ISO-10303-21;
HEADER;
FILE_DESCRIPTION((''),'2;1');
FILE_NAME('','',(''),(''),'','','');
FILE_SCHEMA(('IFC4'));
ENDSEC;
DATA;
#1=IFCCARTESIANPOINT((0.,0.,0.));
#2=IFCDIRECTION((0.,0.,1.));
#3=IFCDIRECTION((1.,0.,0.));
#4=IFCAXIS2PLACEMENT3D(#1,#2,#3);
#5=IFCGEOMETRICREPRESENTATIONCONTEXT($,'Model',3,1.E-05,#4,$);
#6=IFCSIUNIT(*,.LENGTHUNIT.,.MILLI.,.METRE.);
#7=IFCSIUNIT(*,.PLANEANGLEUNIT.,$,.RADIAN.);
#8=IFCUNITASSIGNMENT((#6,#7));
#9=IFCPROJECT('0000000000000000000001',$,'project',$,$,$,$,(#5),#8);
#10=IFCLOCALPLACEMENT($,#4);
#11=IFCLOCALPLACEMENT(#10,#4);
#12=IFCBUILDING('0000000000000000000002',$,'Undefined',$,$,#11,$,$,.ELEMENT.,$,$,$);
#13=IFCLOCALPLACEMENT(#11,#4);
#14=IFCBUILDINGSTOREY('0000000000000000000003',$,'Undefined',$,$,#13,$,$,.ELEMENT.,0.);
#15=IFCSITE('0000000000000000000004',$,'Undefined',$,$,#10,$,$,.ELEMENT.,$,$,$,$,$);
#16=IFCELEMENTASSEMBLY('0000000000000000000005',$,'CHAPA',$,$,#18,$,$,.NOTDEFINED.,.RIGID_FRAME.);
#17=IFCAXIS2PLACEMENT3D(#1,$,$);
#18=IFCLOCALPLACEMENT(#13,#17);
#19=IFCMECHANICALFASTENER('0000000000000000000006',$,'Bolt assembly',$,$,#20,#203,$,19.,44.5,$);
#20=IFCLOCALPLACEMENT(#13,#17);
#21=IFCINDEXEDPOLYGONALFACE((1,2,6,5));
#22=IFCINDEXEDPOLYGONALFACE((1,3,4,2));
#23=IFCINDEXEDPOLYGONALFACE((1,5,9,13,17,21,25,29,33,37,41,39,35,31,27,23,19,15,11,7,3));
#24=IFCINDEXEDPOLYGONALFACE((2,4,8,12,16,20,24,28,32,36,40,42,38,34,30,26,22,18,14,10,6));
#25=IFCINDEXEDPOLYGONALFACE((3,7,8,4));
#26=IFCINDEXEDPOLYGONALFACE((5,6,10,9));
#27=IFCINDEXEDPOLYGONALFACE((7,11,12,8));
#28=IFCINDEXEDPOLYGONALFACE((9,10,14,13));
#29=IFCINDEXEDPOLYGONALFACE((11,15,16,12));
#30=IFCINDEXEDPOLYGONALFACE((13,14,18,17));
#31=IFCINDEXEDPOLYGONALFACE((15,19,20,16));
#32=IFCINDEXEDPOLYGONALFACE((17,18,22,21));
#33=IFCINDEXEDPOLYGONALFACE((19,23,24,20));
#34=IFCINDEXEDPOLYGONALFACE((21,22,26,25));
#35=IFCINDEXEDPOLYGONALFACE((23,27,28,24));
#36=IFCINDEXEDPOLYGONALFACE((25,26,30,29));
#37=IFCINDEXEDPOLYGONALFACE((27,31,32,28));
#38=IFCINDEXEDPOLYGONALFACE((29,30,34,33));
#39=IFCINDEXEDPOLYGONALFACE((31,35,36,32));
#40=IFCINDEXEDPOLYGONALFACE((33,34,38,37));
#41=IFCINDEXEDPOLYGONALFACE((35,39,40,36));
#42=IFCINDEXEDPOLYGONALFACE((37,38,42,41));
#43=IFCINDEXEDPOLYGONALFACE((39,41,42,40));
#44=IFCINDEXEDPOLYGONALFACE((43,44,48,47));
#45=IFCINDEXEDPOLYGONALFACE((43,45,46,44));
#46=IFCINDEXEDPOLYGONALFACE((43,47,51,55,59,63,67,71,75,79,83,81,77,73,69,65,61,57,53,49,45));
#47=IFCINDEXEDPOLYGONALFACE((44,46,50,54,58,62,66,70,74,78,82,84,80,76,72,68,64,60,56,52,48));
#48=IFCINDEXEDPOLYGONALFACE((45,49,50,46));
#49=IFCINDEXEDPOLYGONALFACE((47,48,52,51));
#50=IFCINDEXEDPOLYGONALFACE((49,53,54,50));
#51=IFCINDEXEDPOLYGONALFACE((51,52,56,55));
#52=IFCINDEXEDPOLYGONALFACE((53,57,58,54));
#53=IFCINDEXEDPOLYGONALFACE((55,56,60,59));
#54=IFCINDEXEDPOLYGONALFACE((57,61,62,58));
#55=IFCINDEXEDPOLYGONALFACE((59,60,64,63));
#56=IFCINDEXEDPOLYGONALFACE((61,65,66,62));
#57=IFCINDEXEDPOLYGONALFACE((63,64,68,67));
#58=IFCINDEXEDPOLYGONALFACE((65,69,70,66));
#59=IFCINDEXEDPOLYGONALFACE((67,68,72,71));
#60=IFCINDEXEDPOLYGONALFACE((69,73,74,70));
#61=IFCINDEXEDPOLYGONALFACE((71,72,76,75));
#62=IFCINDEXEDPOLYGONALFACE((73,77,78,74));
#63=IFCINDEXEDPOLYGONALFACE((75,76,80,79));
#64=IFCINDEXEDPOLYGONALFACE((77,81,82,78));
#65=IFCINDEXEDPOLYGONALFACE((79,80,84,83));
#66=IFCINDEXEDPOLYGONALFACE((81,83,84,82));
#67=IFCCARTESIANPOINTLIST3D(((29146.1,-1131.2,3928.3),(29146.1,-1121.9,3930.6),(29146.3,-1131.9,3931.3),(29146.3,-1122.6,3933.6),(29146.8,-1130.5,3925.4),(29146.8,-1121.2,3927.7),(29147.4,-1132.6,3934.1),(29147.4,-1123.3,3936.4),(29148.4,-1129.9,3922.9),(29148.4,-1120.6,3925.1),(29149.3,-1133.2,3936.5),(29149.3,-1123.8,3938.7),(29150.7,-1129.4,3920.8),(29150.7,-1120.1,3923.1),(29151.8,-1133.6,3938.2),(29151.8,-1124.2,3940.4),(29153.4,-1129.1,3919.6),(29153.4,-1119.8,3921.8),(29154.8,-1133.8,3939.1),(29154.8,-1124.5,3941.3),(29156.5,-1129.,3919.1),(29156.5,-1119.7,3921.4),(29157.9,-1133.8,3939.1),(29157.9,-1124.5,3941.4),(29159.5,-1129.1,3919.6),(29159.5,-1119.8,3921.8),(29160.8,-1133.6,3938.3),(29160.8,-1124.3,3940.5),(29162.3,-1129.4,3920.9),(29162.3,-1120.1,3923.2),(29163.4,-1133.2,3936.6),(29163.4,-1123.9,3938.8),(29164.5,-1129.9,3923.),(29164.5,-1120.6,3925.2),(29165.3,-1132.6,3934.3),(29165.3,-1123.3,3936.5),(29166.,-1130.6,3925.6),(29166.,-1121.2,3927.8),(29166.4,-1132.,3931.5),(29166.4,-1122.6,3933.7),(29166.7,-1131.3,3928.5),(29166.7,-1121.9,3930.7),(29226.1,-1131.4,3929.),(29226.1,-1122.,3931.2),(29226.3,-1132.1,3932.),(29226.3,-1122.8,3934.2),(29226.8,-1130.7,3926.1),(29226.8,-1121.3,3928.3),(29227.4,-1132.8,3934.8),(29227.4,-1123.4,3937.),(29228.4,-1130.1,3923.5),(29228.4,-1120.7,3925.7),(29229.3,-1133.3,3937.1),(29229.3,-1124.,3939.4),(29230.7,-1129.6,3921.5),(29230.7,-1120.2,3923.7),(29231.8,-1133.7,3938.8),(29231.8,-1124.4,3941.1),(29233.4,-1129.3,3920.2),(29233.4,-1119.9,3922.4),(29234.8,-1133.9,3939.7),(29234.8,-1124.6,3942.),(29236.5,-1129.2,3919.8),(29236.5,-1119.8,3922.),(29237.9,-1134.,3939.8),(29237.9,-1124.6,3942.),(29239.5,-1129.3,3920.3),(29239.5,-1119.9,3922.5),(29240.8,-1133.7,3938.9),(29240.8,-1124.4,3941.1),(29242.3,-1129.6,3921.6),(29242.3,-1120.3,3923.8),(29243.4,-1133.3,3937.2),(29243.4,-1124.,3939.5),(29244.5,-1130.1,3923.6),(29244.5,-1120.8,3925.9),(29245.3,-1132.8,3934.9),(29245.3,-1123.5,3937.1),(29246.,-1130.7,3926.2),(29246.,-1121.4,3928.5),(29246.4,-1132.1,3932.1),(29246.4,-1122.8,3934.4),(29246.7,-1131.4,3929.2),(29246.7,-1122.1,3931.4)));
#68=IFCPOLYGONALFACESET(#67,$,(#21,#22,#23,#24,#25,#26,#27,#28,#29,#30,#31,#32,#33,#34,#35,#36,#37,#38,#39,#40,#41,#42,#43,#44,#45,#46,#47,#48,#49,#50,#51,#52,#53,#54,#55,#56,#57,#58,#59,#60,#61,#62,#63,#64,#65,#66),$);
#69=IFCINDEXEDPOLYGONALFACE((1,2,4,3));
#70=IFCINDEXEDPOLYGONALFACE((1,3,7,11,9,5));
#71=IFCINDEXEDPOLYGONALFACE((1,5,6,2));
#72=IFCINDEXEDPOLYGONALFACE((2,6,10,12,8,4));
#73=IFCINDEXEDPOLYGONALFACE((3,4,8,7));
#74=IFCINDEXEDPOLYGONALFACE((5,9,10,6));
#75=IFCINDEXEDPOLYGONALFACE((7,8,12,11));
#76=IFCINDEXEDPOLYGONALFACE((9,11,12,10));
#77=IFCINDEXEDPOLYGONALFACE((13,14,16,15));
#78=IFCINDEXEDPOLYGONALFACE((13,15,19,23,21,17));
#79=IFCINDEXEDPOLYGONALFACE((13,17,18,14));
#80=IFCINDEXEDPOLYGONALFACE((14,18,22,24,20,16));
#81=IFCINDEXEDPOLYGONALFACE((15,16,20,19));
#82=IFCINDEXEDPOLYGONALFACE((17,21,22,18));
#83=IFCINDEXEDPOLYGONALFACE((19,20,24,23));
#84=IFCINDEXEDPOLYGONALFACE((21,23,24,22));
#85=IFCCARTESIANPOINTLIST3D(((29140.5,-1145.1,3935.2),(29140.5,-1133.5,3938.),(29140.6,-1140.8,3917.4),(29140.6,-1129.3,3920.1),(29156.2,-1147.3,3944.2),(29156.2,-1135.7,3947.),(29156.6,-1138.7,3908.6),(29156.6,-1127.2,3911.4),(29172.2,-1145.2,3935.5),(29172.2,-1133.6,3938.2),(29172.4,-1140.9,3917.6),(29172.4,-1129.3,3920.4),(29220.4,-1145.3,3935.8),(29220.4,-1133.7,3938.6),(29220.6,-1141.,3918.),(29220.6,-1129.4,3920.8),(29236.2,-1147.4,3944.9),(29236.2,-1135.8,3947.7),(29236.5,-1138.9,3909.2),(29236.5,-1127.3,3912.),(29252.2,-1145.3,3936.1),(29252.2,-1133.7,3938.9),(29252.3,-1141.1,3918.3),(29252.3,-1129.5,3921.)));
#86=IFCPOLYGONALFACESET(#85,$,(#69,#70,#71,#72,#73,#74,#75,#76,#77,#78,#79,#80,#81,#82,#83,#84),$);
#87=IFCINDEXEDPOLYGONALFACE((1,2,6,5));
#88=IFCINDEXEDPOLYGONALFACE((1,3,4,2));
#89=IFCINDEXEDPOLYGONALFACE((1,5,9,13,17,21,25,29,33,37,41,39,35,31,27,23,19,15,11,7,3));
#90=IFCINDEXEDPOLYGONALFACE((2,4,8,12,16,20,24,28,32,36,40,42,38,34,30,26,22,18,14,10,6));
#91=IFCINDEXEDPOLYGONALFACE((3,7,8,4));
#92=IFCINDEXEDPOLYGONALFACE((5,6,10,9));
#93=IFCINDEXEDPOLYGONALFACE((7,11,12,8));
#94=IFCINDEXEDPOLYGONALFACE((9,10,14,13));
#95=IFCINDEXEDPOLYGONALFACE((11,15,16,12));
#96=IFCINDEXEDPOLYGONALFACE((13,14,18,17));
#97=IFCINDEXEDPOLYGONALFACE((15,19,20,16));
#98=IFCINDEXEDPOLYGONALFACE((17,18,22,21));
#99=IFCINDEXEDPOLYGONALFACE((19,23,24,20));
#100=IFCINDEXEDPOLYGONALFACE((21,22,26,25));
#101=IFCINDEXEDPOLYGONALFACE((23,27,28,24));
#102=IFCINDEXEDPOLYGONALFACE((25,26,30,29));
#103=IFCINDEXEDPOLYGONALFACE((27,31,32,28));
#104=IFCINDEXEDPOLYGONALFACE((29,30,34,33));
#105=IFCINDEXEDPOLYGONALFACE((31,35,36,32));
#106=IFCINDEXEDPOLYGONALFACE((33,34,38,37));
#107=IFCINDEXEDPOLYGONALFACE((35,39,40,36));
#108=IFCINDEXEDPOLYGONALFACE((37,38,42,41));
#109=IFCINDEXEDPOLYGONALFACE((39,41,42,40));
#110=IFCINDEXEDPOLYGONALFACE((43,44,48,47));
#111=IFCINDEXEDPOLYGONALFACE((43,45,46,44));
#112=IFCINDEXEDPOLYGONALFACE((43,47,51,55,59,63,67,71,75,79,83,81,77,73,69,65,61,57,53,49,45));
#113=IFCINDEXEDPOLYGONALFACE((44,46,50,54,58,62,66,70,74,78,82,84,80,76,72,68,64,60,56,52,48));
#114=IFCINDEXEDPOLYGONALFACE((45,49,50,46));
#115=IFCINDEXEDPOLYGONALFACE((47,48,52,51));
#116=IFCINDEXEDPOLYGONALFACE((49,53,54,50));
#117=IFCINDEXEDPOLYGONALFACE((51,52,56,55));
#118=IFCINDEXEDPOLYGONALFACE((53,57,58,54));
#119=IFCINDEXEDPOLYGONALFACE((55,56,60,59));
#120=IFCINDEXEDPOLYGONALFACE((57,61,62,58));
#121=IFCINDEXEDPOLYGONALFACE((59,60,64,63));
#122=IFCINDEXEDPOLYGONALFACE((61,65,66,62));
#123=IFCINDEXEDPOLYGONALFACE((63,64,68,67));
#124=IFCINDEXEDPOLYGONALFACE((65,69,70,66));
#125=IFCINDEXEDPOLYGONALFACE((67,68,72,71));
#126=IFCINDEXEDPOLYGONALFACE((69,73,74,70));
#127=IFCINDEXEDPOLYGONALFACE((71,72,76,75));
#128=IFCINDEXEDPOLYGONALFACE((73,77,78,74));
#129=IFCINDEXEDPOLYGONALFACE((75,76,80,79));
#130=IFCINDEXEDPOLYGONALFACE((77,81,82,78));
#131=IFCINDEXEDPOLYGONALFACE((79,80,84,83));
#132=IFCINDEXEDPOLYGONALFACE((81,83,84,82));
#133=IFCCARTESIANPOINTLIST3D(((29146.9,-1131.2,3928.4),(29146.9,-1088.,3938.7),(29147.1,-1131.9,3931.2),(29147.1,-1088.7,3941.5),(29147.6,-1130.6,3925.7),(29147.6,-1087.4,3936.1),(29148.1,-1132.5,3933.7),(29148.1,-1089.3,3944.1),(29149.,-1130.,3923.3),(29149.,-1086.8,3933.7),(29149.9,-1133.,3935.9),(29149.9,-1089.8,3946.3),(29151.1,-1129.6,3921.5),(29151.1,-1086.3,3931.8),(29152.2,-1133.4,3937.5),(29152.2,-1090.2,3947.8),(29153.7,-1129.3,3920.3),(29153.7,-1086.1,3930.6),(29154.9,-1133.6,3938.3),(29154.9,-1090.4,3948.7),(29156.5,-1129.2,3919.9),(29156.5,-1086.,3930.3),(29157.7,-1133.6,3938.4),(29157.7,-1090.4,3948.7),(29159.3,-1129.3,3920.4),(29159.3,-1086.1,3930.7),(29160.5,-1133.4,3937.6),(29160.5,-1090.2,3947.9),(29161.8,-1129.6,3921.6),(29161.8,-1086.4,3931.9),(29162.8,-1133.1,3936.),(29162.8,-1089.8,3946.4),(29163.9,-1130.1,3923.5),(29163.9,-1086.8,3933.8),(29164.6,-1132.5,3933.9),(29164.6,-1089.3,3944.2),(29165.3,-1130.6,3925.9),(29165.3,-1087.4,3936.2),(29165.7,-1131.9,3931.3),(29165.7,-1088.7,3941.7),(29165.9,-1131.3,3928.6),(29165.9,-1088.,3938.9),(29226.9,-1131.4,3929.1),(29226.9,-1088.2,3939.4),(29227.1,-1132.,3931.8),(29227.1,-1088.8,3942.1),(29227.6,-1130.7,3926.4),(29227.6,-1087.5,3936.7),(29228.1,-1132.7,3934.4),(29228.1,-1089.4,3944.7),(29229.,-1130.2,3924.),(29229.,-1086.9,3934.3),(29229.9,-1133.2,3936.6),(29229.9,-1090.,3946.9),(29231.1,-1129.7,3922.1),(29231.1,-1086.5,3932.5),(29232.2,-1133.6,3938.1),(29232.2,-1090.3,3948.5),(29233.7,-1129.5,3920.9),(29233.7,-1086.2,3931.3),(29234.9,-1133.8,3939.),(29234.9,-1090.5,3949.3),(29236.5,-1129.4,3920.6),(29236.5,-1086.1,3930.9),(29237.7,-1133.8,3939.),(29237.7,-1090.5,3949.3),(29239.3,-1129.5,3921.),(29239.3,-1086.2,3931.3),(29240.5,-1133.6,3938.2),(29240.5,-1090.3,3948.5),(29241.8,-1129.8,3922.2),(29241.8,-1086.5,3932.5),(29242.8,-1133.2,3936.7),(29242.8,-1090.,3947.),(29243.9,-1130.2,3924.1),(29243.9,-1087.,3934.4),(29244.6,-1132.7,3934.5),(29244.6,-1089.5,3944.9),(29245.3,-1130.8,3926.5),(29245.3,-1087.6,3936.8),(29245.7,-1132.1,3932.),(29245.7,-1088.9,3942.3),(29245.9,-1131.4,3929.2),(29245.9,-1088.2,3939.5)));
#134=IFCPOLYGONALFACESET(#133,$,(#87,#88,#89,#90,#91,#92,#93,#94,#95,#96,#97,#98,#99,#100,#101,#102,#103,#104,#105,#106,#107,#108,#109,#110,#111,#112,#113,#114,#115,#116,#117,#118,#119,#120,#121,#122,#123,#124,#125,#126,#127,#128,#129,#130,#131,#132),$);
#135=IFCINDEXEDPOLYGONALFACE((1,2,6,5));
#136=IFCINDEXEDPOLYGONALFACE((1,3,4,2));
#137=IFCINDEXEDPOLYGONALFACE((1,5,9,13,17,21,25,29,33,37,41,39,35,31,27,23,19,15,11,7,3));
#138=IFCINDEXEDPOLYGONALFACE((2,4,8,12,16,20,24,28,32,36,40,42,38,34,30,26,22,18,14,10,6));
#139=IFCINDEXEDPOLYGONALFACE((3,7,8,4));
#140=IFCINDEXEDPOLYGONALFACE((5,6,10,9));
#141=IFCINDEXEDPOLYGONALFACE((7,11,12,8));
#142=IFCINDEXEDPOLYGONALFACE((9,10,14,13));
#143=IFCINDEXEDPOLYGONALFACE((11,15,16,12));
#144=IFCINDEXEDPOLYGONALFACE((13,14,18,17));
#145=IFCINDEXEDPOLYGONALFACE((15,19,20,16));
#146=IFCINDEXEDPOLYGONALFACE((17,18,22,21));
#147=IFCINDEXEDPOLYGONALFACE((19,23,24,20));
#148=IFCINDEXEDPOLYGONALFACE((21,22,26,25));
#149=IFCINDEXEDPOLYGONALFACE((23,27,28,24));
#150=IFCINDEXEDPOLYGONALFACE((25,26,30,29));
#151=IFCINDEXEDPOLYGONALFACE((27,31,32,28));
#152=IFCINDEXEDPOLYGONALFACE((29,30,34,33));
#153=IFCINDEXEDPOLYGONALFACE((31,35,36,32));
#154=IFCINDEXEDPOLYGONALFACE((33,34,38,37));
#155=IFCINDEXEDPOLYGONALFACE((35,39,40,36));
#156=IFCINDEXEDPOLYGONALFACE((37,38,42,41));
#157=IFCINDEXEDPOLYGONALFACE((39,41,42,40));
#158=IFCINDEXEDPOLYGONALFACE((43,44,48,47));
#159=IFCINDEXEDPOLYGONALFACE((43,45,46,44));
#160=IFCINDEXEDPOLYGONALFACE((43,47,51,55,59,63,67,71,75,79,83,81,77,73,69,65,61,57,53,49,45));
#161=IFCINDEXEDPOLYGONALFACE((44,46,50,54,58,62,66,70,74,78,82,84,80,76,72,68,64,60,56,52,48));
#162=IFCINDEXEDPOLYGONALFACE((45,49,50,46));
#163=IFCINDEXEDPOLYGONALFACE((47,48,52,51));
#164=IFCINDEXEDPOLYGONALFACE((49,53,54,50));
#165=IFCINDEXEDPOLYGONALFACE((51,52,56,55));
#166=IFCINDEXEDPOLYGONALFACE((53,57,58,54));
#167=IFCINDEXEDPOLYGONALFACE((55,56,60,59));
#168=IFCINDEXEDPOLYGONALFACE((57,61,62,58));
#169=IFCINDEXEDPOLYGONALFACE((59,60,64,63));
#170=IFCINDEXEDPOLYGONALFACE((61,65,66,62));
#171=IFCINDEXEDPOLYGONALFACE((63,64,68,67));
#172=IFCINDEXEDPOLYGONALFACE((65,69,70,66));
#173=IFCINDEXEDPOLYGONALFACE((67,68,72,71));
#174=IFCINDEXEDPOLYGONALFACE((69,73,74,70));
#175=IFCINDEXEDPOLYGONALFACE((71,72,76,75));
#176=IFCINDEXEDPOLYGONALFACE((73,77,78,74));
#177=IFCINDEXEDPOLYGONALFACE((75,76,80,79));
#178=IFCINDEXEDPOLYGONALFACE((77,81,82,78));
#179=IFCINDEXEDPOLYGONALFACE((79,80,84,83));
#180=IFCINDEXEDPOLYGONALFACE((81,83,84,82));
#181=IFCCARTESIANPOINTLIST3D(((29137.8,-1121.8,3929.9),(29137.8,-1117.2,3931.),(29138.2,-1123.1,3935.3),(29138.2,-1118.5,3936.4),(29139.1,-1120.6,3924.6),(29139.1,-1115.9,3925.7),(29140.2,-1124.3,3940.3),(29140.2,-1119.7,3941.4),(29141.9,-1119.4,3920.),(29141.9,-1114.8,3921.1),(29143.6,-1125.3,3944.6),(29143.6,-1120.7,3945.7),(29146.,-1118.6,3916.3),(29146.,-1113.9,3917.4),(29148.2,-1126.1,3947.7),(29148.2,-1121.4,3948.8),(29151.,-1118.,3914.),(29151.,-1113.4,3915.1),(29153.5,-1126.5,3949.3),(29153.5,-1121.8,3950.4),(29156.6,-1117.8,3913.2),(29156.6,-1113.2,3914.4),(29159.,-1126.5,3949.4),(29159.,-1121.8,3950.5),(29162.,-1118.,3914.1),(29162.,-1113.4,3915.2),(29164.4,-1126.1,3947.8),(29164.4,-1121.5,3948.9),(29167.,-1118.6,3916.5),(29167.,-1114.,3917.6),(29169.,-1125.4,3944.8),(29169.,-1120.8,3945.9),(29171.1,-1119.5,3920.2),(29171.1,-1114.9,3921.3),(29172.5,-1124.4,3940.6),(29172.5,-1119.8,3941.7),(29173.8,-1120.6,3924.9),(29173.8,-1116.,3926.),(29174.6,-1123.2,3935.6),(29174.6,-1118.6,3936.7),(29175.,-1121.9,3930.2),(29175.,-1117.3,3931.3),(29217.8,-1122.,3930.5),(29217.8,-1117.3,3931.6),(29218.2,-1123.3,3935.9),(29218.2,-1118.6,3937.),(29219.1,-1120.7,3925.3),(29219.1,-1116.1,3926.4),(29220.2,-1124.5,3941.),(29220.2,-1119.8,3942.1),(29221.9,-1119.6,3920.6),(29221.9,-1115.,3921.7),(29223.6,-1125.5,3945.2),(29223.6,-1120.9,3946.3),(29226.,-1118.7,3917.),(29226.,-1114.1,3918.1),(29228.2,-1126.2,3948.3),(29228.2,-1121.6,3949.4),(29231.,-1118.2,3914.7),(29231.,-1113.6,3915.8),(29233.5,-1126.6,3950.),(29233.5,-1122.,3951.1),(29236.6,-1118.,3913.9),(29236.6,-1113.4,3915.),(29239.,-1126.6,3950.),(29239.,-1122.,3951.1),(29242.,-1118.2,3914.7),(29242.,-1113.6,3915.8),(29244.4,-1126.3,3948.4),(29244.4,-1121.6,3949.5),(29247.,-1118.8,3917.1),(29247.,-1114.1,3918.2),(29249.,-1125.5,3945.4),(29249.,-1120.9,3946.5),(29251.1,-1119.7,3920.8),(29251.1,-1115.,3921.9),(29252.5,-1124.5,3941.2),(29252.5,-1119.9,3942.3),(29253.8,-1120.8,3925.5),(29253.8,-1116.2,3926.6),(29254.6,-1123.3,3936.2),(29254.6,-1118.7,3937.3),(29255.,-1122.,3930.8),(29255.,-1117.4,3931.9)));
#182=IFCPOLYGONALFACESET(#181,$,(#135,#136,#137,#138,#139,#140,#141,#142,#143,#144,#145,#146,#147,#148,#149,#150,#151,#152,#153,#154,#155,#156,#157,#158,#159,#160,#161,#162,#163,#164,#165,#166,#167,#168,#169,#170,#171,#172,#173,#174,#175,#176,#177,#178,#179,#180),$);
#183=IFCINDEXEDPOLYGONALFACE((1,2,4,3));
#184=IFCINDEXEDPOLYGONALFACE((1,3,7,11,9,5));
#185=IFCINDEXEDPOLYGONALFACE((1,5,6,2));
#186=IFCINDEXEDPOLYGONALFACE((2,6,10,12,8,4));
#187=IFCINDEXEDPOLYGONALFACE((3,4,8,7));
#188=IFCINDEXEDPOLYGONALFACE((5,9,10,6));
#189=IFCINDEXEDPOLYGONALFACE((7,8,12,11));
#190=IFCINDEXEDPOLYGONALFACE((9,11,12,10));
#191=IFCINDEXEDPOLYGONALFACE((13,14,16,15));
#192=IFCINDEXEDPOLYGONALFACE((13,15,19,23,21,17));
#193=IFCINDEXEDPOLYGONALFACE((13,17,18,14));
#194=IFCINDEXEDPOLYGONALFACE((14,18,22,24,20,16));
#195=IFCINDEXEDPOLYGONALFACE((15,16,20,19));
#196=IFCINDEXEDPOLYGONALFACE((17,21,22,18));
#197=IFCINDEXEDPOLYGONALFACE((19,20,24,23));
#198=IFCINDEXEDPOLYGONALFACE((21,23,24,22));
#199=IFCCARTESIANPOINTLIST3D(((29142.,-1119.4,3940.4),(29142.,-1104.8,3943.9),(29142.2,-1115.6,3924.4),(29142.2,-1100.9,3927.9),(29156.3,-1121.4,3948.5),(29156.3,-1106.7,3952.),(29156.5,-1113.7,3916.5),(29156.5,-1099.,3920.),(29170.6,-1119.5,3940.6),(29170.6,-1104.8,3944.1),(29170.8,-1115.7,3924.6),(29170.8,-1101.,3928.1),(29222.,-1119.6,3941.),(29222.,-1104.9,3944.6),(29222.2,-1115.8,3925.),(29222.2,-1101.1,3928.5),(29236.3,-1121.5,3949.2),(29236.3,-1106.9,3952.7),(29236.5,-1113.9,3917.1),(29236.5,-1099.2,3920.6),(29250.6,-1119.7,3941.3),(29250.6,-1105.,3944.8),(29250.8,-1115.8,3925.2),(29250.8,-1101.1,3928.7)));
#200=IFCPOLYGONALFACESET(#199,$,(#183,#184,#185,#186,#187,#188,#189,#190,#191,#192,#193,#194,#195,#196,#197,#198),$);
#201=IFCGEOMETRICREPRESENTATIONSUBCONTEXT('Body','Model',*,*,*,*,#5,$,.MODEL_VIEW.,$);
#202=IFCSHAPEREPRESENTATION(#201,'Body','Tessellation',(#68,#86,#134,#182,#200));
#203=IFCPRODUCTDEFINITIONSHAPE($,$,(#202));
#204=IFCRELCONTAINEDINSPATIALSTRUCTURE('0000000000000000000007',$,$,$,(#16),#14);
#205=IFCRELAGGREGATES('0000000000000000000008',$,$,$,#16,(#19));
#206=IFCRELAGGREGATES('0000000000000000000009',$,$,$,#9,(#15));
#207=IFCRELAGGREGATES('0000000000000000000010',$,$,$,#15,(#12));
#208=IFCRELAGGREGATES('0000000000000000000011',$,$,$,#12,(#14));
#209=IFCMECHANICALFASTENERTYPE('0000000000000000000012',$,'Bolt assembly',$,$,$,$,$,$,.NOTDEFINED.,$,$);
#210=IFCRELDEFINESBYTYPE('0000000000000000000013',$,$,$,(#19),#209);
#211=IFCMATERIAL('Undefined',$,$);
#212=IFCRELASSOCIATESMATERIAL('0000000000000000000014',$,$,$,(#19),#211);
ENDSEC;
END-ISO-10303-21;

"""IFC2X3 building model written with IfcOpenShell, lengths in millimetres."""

from ifc_helpers import new_model, si_unit, frame, origin_with_axes, origin_2d_with_axis, place, context, subcontext, project, spatial, polyline, circle, outline, extrude, source, transform, mapped, material, type_object, element, aggregate, save


model = new_model("IFC2X3")

# Units and contexts
model_context = context("Model", 3, precision=1e-05, world=origin_with_axes())
body_context = subcontext(model_context, "Body", "Model", "MODEL_VIEW")
ifc_project = project(units=[si_unit("LENGTHUNIT", "METRE", prefix="MILLI"), si_unit("PLANEANGLEUNIT", "RADIAN")], contexts=[model_context])

# Site, building, storey
site_placement = place(None, origin_with_axes())
site = spatial("IfcSite", under=ifc_project, at=site_placement, Name="Undefined", CompositionType="ELEMENT")
building_placement = place(site_placement, origin_with_axes())
building = spatial("IfcBuilding", under=site, at=building_placement, Name="Undefined", CompositionType="ELEMENT")
storey_placement = place(building_placement, origin_with_axes())
storey = spatial("IfcBuildingStorey", under=building, at=storey_placement, Name="Undefined", CompositionType="ELEMENT", Elevation=0.0)

# Element assembly
assembly_1_placement = place(storey_placement, origin_with_axes())
assembly_1 = element("IfcElementAssembly", 1, at=assembly_1_placement, inside=storey, Name="CHAPA", AssemblyPlace="NOTDEFINED", PredefinedType="RIGID_FRAME")

# Shared definitions
ifc_material_1 = material(Name="Undefined")
mechanical_fastener_type = type_object("IfcMechanicalFastenerType", Name="Bolt assembly")

# Mechanical fastener
shared_shape_1 = source(origin_with_axes(), body_context, "Body", "SweptSolid", [
    extrude(circle(Radius=10.3, at=origin_2d_with_axis()), frame((0.0, 0.0, 0.0), z_axis=(0.0, 1.0, 0.0), x_axis=(1.0, 0.0, 0.0)), (0.0, 0.0, 1.0), 9.6),
    extrude(outline(polyline([(18.3, 0.0), (9.2, 15.9), (-9.2, 15.9), (-18.3, 0.0), (-9.2, -15.9), (9.2, -15.9), (18.3, 0.0)])), frame((0.0, -11.9, 0.0), z_axis=(0.0, 1.0, 0.0), x_axis=(1.0, 0.0, 0.0)), (0.0, 0.0, 1.0), 11.9),
    extrude(circle(Radius=9.5, at=origin_2d_with_axis()), frame((0.0, 0.0, 0.0), z_axis=(0.0, 1.0, 0.0), x_axis=(1.0, 0.0, 0.0)), (0.0, 0.0, 1.0), 44.5),
    extrude(circle(Radius=18.7, at=origin_2d_with_axis()), frame((0.0, 9.5, 0.0), z_axis=(0.0, 1.0, 0.0), x_axis=(1.0, 0.0, 0.0)), (0.0, 0.0, 1.0), 4.8),
    extrude(outline(polyline([(16.5, 0.0), (8.2, 14.3), (-8.2, 14.3), (-16.5, 0.0), (-8.2, -14.3), (8.2, -14.3), (16.5, 0.0)])), frame((0.0, 14.3, 0.0), z_axis=(0.0, 1.0, 0.0), x_axis=(1.0, 0.0, 0.0)), (0.0, 0.0, 1.0), 15.1),
])
mechanical_fastener_1_placement = place(assembly_1_placement, frame((29196.4, -1131.5, 3929.5), z_axis=(0.999966, -0.001918, 0.008027), x_axis=(0.008253, 0.23249, -0.972564)))
mechanical_fastener_1 = element("IfcMechanicalFastener", 2, at=mechanical_fastener_1_placement, type_object=mechanical_fastener_type, material=ifc_material_1, Name="Bolt assembly", NominalDiameter=19.0, NominalLength=44.5, context=body_context, shape_type="MappedRepresentation", body=[
    mapped(shared_shape_1, transform((0.0, 0.0, -40.0))),
    mapped(shared_shape_1, transform((0.0, 0.0, 40.0))),
])
aggregate(assembly_1, [mechanical_fastener_1])

save(model, "model.ifc")
